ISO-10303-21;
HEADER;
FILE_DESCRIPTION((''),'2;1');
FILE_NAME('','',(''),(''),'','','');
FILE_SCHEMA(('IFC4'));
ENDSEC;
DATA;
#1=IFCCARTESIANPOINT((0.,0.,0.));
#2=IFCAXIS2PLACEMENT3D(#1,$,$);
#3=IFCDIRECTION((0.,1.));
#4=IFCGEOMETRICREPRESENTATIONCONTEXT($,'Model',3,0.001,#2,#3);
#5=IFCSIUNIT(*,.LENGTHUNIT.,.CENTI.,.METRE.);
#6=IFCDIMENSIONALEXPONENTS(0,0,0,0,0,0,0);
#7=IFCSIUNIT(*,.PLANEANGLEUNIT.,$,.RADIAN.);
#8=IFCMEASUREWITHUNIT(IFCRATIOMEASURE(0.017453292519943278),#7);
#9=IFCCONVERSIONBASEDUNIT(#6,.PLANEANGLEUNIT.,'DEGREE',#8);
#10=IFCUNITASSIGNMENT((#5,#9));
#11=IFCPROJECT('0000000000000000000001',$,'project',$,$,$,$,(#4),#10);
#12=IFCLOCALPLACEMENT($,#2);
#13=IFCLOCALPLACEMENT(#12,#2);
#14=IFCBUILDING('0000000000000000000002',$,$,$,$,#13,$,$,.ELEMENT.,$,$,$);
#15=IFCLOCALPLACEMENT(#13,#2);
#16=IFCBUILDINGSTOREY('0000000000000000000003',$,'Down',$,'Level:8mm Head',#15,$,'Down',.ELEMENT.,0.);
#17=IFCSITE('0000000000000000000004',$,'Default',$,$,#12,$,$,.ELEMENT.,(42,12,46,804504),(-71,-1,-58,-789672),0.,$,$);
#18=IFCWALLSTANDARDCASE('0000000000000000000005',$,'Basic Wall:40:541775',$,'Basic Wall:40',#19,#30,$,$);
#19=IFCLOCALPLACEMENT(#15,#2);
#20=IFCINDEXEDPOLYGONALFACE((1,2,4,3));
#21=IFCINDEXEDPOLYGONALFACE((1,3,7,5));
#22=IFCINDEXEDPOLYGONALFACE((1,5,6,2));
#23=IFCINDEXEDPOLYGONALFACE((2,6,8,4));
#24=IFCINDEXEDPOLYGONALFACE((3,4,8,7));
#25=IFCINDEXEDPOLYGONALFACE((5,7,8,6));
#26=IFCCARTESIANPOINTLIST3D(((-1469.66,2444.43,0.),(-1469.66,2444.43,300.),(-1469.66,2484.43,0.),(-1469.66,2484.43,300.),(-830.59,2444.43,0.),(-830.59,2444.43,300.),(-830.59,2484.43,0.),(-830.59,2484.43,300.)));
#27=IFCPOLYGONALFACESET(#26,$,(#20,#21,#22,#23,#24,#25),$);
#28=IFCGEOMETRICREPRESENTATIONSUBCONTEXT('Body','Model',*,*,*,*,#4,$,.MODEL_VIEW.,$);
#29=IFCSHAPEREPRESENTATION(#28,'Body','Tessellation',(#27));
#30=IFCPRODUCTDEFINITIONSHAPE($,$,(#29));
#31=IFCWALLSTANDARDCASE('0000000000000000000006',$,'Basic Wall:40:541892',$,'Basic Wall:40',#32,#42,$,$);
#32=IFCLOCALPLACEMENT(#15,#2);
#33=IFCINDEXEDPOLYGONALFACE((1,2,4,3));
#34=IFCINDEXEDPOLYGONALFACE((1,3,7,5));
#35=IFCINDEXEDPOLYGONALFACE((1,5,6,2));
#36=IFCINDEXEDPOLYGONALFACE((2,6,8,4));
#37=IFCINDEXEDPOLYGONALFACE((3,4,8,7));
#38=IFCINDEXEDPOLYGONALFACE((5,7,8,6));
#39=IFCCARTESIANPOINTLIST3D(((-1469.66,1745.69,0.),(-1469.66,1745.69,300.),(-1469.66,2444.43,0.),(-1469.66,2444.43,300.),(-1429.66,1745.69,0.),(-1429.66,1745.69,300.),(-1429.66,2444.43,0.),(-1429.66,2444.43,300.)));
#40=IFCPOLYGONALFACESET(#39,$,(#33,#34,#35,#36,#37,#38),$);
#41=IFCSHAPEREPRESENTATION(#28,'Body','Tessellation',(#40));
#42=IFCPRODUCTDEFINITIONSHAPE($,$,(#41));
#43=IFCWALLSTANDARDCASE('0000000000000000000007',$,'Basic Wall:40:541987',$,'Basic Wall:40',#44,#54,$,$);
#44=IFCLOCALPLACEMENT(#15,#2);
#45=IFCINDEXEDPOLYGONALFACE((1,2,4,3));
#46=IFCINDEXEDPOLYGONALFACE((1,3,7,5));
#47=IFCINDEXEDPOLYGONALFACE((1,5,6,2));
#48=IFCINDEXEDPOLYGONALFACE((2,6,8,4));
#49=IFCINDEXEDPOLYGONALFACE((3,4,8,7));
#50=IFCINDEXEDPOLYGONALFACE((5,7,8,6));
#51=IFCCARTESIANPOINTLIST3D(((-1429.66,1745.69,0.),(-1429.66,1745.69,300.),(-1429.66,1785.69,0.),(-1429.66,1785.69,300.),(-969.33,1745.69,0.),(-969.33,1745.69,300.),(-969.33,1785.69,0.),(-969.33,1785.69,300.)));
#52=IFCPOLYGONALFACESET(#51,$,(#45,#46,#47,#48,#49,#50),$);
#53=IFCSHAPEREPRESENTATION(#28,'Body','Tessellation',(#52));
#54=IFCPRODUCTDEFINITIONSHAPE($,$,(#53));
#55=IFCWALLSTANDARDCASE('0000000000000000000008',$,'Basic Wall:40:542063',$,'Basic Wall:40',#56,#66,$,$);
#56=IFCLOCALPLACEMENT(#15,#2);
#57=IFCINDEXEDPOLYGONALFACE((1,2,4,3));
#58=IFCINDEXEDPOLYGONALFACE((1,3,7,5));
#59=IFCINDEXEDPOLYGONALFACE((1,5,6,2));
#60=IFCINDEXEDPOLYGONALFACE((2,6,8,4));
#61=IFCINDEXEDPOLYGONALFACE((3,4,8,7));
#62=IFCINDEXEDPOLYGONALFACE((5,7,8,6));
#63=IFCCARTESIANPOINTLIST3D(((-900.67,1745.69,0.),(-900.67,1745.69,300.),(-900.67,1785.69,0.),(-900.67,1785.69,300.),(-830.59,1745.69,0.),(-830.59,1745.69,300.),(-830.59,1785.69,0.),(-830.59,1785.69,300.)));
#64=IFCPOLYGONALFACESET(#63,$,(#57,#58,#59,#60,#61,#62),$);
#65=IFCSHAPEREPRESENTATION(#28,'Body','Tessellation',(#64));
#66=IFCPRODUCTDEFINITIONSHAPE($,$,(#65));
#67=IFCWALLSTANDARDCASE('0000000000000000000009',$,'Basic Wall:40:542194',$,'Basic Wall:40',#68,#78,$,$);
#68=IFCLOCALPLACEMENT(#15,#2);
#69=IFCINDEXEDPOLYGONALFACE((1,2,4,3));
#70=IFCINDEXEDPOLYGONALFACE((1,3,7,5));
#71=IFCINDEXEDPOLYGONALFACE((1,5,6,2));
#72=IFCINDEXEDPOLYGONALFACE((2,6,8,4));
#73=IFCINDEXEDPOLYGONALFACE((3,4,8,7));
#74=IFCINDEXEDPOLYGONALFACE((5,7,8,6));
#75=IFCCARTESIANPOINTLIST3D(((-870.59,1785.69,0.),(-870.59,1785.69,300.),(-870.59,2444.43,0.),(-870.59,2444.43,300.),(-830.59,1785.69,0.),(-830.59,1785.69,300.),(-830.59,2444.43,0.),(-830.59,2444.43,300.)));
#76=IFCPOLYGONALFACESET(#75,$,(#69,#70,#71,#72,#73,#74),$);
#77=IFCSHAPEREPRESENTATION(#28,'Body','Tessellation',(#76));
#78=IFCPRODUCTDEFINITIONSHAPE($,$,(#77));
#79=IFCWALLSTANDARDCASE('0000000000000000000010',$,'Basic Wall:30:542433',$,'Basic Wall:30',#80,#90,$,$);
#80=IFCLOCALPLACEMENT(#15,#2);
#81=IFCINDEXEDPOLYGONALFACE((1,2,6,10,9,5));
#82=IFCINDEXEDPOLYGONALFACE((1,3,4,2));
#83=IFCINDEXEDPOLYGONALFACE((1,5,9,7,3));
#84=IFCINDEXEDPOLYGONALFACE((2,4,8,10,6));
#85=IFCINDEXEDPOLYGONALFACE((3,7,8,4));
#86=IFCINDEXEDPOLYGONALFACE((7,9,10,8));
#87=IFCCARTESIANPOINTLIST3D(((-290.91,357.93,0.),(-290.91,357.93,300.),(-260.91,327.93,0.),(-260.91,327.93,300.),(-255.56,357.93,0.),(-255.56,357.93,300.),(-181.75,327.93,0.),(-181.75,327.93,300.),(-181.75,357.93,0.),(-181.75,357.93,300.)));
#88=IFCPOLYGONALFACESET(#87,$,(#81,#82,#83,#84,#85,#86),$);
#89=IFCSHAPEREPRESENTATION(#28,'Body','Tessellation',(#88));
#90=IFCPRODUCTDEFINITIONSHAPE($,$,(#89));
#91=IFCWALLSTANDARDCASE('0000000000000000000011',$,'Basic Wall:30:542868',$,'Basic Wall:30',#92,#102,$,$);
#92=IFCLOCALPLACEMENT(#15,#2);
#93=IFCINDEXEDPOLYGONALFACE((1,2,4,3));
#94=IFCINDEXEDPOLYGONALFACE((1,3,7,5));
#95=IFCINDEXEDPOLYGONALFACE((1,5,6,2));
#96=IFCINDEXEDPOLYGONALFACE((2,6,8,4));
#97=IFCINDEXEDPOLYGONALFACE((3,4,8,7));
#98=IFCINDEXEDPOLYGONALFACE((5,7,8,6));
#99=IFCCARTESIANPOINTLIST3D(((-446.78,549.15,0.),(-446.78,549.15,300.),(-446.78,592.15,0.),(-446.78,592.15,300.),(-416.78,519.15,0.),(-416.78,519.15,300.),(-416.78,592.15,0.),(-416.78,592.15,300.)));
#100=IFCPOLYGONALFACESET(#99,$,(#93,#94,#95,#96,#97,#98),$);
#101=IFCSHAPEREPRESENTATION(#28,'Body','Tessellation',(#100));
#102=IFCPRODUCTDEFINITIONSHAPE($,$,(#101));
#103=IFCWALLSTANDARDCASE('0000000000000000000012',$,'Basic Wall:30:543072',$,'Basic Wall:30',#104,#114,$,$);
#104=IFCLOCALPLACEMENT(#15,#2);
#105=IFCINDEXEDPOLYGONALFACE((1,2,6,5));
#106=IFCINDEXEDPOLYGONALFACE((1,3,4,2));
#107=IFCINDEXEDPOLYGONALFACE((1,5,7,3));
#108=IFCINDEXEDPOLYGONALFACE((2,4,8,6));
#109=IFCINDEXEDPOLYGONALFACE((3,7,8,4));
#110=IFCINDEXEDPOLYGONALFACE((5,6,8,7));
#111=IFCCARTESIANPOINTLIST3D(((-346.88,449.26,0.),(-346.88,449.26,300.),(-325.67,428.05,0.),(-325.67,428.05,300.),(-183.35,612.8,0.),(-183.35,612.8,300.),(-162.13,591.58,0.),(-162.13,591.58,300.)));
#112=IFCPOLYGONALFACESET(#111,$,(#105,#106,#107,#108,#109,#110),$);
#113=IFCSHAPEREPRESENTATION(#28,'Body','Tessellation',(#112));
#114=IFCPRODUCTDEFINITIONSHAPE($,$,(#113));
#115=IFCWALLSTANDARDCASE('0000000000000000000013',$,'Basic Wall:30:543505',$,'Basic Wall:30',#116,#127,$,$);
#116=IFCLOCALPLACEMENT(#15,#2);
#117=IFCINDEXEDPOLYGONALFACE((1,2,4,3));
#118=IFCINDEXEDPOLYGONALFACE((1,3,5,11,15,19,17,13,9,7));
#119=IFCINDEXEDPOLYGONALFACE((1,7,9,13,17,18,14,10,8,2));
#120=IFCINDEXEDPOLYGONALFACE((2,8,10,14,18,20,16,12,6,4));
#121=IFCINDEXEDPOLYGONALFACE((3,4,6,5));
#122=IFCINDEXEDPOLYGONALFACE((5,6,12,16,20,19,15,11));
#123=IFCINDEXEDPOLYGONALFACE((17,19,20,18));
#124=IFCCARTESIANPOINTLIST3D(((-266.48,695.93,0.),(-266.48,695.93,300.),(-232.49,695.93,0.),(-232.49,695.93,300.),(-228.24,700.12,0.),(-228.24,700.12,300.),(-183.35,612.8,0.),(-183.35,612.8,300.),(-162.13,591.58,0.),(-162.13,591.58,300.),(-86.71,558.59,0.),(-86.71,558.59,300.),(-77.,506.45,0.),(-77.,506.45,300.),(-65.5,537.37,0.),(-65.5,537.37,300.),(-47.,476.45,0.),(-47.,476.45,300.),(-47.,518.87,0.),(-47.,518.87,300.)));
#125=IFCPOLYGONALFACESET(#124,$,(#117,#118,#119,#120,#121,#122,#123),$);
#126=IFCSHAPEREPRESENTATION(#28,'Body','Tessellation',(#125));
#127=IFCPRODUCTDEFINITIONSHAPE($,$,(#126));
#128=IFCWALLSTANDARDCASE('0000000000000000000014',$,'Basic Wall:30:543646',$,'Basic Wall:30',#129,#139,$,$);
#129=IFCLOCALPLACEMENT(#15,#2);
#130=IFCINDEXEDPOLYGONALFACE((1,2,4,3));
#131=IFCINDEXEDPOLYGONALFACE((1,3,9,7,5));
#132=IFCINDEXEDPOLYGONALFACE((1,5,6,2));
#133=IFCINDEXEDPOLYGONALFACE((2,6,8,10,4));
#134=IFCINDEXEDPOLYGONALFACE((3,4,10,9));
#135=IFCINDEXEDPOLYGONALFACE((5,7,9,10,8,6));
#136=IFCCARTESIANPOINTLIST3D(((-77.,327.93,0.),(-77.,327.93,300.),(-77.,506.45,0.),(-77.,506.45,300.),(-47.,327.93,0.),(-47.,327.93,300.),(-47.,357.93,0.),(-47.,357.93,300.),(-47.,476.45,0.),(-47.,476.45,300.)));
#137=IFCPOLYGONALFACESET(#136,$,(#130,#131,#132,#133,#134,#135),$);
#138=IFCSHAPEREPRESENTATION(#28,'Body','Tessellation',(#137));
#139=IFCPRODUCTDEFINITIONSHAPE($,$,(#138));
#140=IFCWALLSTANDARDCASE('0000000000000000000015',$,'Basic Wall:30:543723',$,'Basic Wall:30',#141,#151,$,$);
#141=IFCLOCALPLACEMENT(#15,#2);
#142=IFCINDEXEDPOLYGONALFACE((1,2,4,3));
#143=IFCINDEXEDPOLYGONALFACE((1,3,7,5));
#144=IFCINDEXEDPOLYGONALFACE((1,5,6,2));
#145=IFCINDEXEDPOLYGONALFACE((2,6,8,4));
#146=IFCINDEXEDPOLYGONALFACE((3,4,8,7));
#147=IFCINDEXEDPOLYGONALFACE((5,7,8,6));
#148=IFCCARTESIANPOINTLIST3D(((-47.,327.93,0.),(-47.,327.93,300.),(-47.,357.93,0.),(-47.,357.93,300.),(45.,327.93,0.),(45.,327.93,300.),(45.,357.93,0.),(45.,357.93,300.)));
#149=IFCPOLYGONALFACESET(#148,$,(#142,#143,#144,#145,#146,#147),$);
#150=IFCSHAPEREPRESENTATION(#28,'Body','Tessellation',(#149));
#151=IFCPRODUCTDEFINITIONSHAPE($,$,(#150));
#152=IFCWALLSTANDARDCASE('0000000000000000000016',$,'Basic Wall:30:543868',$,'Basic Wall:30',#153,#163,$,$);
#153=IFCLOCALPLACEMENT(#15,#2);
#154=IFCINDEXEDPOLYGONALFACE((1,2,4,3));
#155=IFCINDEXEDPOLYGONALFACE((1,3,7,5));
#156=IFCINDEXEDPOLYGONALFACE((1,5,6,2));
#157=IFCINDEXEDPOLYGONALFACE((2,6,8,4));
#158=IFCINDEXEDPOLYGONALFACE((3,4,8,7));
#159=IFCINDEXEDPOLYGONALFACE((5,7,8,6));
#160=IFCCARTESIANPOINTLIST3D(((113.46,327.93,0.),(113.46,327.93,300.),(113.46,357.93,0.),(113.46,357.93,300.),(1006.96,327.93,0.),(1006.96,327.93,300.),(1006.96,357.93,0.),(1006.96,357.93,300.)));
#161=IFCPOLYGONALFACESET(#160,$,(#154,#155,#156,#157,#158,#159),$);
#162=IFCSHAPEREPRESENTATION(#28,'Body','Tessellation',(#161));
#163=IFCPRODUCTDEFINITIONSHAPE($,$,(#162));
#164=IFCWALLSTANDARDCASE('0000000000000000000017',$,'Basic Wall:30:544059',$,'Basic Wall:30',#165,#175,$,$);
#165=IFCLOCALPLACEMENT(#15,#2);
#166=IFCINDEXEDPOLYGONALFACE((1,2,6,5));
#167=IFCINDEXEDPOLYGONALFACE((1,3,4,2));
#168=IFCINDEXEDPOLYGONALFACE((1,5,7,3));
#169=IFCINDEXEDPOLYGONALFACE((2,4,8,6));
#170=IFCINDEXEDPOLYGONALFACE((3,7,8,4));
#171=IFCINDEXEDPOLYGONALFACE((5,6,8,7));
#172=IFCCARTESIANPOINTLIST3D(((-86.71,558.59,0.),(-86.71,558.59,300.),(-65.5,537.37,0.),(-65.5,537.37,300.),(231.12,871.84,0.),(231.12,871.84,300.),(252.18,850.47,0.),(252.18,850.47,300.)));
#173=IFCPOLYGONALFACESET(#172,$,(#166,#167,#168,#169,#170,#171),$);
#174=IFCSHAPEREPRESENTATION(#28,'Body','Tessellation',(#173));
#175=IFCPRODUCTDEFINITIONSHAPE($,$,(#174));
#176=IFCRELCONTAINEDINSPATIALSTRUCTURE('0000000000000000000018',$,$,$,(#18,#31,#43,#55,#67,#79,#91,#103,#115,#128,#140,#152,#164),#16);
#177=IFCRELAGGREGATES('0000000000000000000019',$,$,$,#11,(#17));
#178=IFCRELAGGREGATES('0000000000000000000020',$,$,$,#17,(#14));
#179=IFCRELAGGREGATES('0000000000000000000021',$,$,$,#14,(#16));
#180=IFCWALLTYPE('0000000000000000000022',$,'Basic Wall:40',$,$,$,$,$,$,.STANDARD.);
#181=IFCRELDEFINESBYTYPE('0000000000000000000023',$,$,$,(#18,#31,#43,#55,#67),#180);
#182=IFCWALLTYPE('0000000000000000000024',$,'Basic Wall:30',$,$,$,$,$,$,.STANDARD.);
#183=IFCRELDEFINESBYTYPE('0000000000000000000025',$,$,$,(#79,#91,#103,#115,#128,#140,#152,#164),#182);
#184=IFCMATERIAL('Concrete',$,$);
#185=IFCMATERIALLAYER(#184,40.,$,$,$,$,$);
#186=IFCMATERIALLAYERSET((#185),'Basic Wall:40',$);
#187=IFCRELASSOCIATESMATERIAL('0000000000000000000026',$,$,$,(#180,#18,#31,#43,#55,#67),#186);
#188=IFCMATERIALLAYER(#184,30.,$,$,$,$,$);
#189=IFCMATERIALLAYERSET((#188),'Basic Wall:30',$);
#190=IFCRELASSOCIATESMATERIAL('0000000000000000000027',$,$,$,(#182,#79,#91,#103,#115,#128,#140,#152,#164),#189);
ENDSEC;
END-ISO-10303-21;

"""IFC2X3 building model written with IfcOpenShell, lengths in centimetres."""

from ifc_helpers import new_model, entity, si_unit, converted_unit, direction, frame, frame_2d, origin, place, context, subcontext, project, spatial, polyline, rectangle, outline, extrude, material, layer, layer_set, layer_usage, type_object, element, save


model = new_model("IFC2X3")

# Units and contexts
model_context = context("Model", 3, precision=0.001, world=origin(), true_north=direction((0.0, 1.0)))
body_context = subcontext(model_context, "Body", "Model", "MODEL_VIEW")
ifc_project = project(units=[si_unit("LENGTHUNIT", "METRE", prefix="CENTI"), converted_unit("PLANEANGLEUNIT", "DEGREE", entity("IfcRatioMeasure", 0.017453292519943278), si_unit("PLANEANGLEUNIT", "RADIAN"), dimensions=[0, 0, 0, 0, 0, 0, 0])], contexts=[model_context])

# Site, building, storey
site_placement = place(None, origin())
site = spatial("IfcSite", under=ifc_project, at=site_placement, Name="Default", CompositionType="ELEMENT", RefLatitude=(42, 12, 46, 804504), RefLongitude=(-71, -1, -58, -789672), RefElevation=0.0)
building_placement = place(site_placement, origin())
building = spatial("IfcBuilding", under=site, at=building_placement, CompositionType="ELEMENT")
storey_placement = place(building_placement, origin())
storey = spatial("IfcBuildingStorey", under=building, at=storey_placement, Name="Down", ObjectType="Level:8mm Head", LongName="Down", CompositionType="ELEMENT", Elevation=0.0)

# Walls
ifc_material = material(Name="Concrete")
ifc_layer_1 = layer(ifc_material, 40.0)
ifc_layer_set_1 = layer_set([ifc_layer_1], Name="Basic Wall:40")
ifc_layer_usage_1 = layer_usage(ifc_layer_set_1, "AXIS2", "POSITIVE", -20.0)
wall_type_1 = type_object("IfcWallType", Name="Basic Wall:40", PredefinedType="STANDARD", material=ifc_layer_set_1)
wall_1_placement = place(storey_placement, frame((-830.59, 2464.43, 0.0), z_axis=(0.0, 0.0, 1.0), x_axis=(-1.0, 0.0, 0.0)))
element("IfcWallStandardCase", 1, at=wall_1_placement, inside=storey, type_object=wall_type_1, material=ifc_layer_usage_1, Name="Basic Wall:40:541775", ObjectType="Basic Wall:40", context=body_context, shape_type="SweptSolid", body=[
    extrude(rectangle(XDim=639.08, YDim=40.0, at=frame_2d((319.54, 0.0), x_axis=(-1.0, 0.0))), origin(), (0.0, 0.0, 1.0), 300.0),
])
ifc_layer_usage_2 = layer_usage(ifc_layer_set_1, "AXIS2", "POSITIVE", -20.0)
wall_2_placement = place(storey_placement, frame((-1449.66, 2444.43, 0.0), z_axis=(0.0, 0.0, 1.0), x_axis=(0.0, -1.0, 0.0)))
element("IfcWallStandardCase", 2, at=wall_2_placement, inside=storey, type_object=wall_type_1, material=ifc_layer_usage_2, Name="Basic Wall:40:541892", ObjectType="Basic Wall:40", context=body_context, shape_type="SweptSolid", body=[
    extrude(rectangle(XDim=698.74, YDim=40.0, at=frame_2d((349.37, 0.0), x_axis=(-1.0, 0.0))), origin(), (0.0, 0.0, 1.0), 300.0),
])
ifc_layer_usage_3 = layer_usage(ifc_layer_set_1, "AXIS2", "POSITIVE", -20.0)
wall_3_placement = place(storey_placement, frame((-1429.66, 1765.69, 0.0)))
element("IfcWallStandardCase", 3, at=wall_3_placement, inside=storey, type_object=wall_type_1, material=ifc_layer_usage_3, Name="Basic Wall:40:541987", ObjectType="Basic Wall:40", context=body_context, shape_type="SweptSolid", body=[
    extrude(rectangle(XDim=460.33, YDim=40.0, at=frame_2d((230.17, 0.0), x_axis=(-1.0, 0.0))), origin(), (0.0, 0.0, 1.0), 300.0),
])
ifc_layer_usage_4 = layer_usage(ifc_layer_set_1, "AXIS2", "POSITIVE", -20.0)
wall_4_placement = place(storey_placement, frame((-900.67, 1765.69, 0.0)))
element("IfcWallStandardCase", 4, at=wall_4_placement, inside=storey, type_object=wall_type_1, material=ifc_layer_usage_4, Name="Basic Wall:40:542063", ObjectType="Basic Wall:40", context=body_context, shape_type="SweptSolid", body=[
    extrude(rectangle(XDim=70.09, YDim=40.0, at=frame_2d((35.04, 0.0), x_axis=(-1.0, 0.0))), origin(), (0.0, 0.0, 1.0), 300.0),
])
ifc_layer_usage_5 = layer_usage(ifc_layer_set_1, "AXIS2", "POSITIVE", -20.0)
wall_5_placement = place(storey_placement, frame((-850.59, 1785.69, 0.0), z_axis=(0.0, 0.0, 1.0), x_axis=(0.0, 1.0, 0.0)))
element("IfcWallStandardCase", 5, at=wall_5_placement, inside=storey, type_object=wall_type_1, material=ifc_layer_usage_5, Name="Basic Wall:40:542194", ObjectType="Basic Wall:40", context=body_context, shape_type="SweptSolid", body=[
    extrude(rectangle(XDim=658.74, YDim=40.0, at=frame_2d((329.37, 0.0), x_axis=(-1.0, 0.0))), origin(), (0.0, 0.0, 1.0), 300.0),
])
ifc_layer_2 = layer(ifc_material, 30.0)
ifc_layer_set_2 = layer_set([ifc_layer_2], Name="Basic Wall:30")
ifc_layer_usage_6 = layer_usage(ifc_layer_set_2, "AXIS2", "POSITIVE", -15.0)
wall_type_2 = type_object("IfcWallType", Name="Basic Wall:30", PredefinedType="STANDARD", material=ifc_layer_set_2)
wall_6_placement = place(storey_placement, frame((-181.75, 342.93, 0.0), z_axis=(0.0, 0.0, 1.0), x_axis=(-1.0, 0.0, 0.0)))
element("IfcWallStandardCase", 6, at=wall_6_placement, inside=storey, type_object=wall_type_2, material=ifc_layer_usage_6, Name="Basic Wall:30:542433", ObjectType="Basic Wall:30", context=body_context, shape_type="SweptSolid", body=[
    extrude(outline(polyline([(109.16, -15.0), (79.16, 15.0), (0.0, 15.0), (0.0, -15.0), (73.8, -15.0), (109.16, -15.0)])), origin(), (0.0, 0.0, 1.0), 300.0),
])
ifc_layer_usage_7 = layer_usage(ifc_layer_set_2, "AXIS2", "POSITIVE", -15.0)
wall_7_placement = place(storey_placement, frame((-431.78, 519.15, 0.0), z_axis=(0.0, 0.0, 1.0), x_axis=(0.0, 1.0, 0.0)))
element("IfcWallStandardCase", 7, at=wall_7_placement, inside=storey, type_object=wall_type_2, material=ifc_layer_usage_7, Name="Basic Wall:30:542868", ObjectType="Basic Wall:30", context=body_context, shape_type="SweptSolid", body=[
    extrude(outline(polyline([(73.0, -15.0), (73.0, 15.0), (30.0, 15.0), (0.0, -15.0), (73.0, -15.0)])), origin(), (0.0, 0.0, 1.0), 300.0),
])
ifc_layer_usage_8 = layer_usage(ifc_layer_set_2, "AXIS2", "NEGATIVE", 15.0)
wall_8_placement = place(storey_placement, frame((-336.27, 438.65, 0.0), z_axis=(0.0, 0.0, 1.0), x_axis=(0.707107, 0.707107, 0.0)))
element("IfcWallStandardCase", 8, at=wall_8_placement, inside=storey, type_object=wall_type_2, material=ifc_layer_usage_8, Name="Basic Wall:30:543072", ObjectType="Basic Wall:30", context=body_context, shape_type="SweptSolid", body=[
    extrude(rectangle(XDim=231.27, YDim=30.0, at=frame_2d((115.64, 0.0), x_axis=(-1.0, 0.0))), origin(), (0.0, 0.0, 1.0), 300.0),
])
ifc_layer_usage_9 = layer_usage(ifc_layer_set_2, "AXIS2", "POSITIVE", -15.0)
wall_9_placement = place(storey_placement, frame((-255.88, 706.54, 0.0), z_axis=(0.0, 0.0, 1.0), x_axis=(0.707107, -0.707107, 0.0)))
element("IfcWallStandardCase", 9, at=wall_9_placement, inside=storey, type_object=wall_type_2, material=ifc_layer_usage_9, Name="Basic Wall:30:543505", ObjectType="Basic Wall:30", context=body_context, shape_type="SweptSolid", body=[
    extrude(outline(polyline([(310.4, -15.0), (280.4, 15.0), (254.24, 15.0), (224.23, 15.0), (24.08, 15.0), (24.04, 9.04), (0.0, -15.0), (117.57, -15.0), (147.57, -15.0), (267.97, -15.0), (310.4, -15.0)])), origin(), (0.0, 0.0, 1.0), 300.0),
])
ifc_layer_usage_10 = layer_usage(ifc_layer_set_2, "AXIS2", "POSITIVE", -15.0)
wall_10_placement = place(storey_placement, frame((-62.0, 506.45, 0.0), z_axis=(0.0, 0.0, 1.0), x_axis=(0.0, -1.0, 0.0)))
element("IfcWallStandardCase", 10, at=wall_10_placement, inside=storey, type_object=wall_type_2, material=ifc_layer_usage_10, Name="Basic Wall:30:543646", ObjectType="Basic Wall:30", context=body_context, shape_type="SweptSolid", body=[
    extrude(outline(polyline([(178.51, -15.0), (178.51, 15.0), (148.51, 15.0), (30.0, 15.0), (0.0, -15.0), (178.51, -15.0)])), origin(), (0.0, 0.0, 1.0), 300.0),
])
ifc_layer_usage_11 = layer_usage(ifc_layer_set_2, "AXIS2", "POSITIVE", -15.0)
wall_11_placement = place(storey_placement, frame((-47.0, 342.93, 0.0)))
element("IfcWallStandardCase", 11, at=wall_11_placement, inside=storey, type_object=wall_type_2, material=ifc_layer_usage_11, Name="Basic Wall:30:543723", ObjectType="Basic Wall:30", context=body_context, shape_type="SweptSolid", body=[
    extrude(rectangle(XDim=92.0, YDim=30.0, at=frame_2d((46.0, 0.0), x_axis=(-1.0, 0.0))), origin(), (0.0, 0.0, 1.0), 300.0),
])
ifc_layer_usage_12 = layer_usage(ifc_layer_set_2, "AXIS2", "POSITIVE", -15.0)
wall_12_placement = place(storey_placement, frame((113.46, 342.93, 0.0)))
element("IfcWallStandardCase", 12, at=wall_12_placement, inside=storey, type_object=wall_type_2, material=ifc_layer_usage_12, Name="Basic Wall:30:543868", ObjectType="Basic Wall:30", context=body_context, shape_type="SweptSolid", body=[
    extrude(rectangle(XDim=893.5, YDim=30.0, at=frame_2d((446.75, 0.0), x_axis=(-1.0, 0.0))), origin(), (0.0, 0.0, 1.0), 300.0),
])
ifc_layer_usage_13 = layer_usage(ifc_layer_set_2, "AXIS2", "POSITIVE", -15.0)
wall_13_placement = place(storey_placement, frame((-76.18, 547.9, 0.0), z_axis=(0.0, 0.0, 1.0), x_axis=(0.712224, 0.701952, 0.0)))
element("IfcWallStandardCase", 13, at=wall_13_placement, inside=storey, type_object=wall_type_2, material=ifc_layer_usage_13, Name="Basic Wall:30:544059", ObjectType="Basic Wall:30", context=body_context, shape_type="SweptSolid", body=[
    extrude(outline(polyline([(446.25, -15.0), (446.25, 15.0), (0.0, 15.0), (0.22, -15.0), (446.25, -15.0)])), origin(), (0.0, 0.0, 1.0), 300.0),
])

save(model, "model.ifc")
